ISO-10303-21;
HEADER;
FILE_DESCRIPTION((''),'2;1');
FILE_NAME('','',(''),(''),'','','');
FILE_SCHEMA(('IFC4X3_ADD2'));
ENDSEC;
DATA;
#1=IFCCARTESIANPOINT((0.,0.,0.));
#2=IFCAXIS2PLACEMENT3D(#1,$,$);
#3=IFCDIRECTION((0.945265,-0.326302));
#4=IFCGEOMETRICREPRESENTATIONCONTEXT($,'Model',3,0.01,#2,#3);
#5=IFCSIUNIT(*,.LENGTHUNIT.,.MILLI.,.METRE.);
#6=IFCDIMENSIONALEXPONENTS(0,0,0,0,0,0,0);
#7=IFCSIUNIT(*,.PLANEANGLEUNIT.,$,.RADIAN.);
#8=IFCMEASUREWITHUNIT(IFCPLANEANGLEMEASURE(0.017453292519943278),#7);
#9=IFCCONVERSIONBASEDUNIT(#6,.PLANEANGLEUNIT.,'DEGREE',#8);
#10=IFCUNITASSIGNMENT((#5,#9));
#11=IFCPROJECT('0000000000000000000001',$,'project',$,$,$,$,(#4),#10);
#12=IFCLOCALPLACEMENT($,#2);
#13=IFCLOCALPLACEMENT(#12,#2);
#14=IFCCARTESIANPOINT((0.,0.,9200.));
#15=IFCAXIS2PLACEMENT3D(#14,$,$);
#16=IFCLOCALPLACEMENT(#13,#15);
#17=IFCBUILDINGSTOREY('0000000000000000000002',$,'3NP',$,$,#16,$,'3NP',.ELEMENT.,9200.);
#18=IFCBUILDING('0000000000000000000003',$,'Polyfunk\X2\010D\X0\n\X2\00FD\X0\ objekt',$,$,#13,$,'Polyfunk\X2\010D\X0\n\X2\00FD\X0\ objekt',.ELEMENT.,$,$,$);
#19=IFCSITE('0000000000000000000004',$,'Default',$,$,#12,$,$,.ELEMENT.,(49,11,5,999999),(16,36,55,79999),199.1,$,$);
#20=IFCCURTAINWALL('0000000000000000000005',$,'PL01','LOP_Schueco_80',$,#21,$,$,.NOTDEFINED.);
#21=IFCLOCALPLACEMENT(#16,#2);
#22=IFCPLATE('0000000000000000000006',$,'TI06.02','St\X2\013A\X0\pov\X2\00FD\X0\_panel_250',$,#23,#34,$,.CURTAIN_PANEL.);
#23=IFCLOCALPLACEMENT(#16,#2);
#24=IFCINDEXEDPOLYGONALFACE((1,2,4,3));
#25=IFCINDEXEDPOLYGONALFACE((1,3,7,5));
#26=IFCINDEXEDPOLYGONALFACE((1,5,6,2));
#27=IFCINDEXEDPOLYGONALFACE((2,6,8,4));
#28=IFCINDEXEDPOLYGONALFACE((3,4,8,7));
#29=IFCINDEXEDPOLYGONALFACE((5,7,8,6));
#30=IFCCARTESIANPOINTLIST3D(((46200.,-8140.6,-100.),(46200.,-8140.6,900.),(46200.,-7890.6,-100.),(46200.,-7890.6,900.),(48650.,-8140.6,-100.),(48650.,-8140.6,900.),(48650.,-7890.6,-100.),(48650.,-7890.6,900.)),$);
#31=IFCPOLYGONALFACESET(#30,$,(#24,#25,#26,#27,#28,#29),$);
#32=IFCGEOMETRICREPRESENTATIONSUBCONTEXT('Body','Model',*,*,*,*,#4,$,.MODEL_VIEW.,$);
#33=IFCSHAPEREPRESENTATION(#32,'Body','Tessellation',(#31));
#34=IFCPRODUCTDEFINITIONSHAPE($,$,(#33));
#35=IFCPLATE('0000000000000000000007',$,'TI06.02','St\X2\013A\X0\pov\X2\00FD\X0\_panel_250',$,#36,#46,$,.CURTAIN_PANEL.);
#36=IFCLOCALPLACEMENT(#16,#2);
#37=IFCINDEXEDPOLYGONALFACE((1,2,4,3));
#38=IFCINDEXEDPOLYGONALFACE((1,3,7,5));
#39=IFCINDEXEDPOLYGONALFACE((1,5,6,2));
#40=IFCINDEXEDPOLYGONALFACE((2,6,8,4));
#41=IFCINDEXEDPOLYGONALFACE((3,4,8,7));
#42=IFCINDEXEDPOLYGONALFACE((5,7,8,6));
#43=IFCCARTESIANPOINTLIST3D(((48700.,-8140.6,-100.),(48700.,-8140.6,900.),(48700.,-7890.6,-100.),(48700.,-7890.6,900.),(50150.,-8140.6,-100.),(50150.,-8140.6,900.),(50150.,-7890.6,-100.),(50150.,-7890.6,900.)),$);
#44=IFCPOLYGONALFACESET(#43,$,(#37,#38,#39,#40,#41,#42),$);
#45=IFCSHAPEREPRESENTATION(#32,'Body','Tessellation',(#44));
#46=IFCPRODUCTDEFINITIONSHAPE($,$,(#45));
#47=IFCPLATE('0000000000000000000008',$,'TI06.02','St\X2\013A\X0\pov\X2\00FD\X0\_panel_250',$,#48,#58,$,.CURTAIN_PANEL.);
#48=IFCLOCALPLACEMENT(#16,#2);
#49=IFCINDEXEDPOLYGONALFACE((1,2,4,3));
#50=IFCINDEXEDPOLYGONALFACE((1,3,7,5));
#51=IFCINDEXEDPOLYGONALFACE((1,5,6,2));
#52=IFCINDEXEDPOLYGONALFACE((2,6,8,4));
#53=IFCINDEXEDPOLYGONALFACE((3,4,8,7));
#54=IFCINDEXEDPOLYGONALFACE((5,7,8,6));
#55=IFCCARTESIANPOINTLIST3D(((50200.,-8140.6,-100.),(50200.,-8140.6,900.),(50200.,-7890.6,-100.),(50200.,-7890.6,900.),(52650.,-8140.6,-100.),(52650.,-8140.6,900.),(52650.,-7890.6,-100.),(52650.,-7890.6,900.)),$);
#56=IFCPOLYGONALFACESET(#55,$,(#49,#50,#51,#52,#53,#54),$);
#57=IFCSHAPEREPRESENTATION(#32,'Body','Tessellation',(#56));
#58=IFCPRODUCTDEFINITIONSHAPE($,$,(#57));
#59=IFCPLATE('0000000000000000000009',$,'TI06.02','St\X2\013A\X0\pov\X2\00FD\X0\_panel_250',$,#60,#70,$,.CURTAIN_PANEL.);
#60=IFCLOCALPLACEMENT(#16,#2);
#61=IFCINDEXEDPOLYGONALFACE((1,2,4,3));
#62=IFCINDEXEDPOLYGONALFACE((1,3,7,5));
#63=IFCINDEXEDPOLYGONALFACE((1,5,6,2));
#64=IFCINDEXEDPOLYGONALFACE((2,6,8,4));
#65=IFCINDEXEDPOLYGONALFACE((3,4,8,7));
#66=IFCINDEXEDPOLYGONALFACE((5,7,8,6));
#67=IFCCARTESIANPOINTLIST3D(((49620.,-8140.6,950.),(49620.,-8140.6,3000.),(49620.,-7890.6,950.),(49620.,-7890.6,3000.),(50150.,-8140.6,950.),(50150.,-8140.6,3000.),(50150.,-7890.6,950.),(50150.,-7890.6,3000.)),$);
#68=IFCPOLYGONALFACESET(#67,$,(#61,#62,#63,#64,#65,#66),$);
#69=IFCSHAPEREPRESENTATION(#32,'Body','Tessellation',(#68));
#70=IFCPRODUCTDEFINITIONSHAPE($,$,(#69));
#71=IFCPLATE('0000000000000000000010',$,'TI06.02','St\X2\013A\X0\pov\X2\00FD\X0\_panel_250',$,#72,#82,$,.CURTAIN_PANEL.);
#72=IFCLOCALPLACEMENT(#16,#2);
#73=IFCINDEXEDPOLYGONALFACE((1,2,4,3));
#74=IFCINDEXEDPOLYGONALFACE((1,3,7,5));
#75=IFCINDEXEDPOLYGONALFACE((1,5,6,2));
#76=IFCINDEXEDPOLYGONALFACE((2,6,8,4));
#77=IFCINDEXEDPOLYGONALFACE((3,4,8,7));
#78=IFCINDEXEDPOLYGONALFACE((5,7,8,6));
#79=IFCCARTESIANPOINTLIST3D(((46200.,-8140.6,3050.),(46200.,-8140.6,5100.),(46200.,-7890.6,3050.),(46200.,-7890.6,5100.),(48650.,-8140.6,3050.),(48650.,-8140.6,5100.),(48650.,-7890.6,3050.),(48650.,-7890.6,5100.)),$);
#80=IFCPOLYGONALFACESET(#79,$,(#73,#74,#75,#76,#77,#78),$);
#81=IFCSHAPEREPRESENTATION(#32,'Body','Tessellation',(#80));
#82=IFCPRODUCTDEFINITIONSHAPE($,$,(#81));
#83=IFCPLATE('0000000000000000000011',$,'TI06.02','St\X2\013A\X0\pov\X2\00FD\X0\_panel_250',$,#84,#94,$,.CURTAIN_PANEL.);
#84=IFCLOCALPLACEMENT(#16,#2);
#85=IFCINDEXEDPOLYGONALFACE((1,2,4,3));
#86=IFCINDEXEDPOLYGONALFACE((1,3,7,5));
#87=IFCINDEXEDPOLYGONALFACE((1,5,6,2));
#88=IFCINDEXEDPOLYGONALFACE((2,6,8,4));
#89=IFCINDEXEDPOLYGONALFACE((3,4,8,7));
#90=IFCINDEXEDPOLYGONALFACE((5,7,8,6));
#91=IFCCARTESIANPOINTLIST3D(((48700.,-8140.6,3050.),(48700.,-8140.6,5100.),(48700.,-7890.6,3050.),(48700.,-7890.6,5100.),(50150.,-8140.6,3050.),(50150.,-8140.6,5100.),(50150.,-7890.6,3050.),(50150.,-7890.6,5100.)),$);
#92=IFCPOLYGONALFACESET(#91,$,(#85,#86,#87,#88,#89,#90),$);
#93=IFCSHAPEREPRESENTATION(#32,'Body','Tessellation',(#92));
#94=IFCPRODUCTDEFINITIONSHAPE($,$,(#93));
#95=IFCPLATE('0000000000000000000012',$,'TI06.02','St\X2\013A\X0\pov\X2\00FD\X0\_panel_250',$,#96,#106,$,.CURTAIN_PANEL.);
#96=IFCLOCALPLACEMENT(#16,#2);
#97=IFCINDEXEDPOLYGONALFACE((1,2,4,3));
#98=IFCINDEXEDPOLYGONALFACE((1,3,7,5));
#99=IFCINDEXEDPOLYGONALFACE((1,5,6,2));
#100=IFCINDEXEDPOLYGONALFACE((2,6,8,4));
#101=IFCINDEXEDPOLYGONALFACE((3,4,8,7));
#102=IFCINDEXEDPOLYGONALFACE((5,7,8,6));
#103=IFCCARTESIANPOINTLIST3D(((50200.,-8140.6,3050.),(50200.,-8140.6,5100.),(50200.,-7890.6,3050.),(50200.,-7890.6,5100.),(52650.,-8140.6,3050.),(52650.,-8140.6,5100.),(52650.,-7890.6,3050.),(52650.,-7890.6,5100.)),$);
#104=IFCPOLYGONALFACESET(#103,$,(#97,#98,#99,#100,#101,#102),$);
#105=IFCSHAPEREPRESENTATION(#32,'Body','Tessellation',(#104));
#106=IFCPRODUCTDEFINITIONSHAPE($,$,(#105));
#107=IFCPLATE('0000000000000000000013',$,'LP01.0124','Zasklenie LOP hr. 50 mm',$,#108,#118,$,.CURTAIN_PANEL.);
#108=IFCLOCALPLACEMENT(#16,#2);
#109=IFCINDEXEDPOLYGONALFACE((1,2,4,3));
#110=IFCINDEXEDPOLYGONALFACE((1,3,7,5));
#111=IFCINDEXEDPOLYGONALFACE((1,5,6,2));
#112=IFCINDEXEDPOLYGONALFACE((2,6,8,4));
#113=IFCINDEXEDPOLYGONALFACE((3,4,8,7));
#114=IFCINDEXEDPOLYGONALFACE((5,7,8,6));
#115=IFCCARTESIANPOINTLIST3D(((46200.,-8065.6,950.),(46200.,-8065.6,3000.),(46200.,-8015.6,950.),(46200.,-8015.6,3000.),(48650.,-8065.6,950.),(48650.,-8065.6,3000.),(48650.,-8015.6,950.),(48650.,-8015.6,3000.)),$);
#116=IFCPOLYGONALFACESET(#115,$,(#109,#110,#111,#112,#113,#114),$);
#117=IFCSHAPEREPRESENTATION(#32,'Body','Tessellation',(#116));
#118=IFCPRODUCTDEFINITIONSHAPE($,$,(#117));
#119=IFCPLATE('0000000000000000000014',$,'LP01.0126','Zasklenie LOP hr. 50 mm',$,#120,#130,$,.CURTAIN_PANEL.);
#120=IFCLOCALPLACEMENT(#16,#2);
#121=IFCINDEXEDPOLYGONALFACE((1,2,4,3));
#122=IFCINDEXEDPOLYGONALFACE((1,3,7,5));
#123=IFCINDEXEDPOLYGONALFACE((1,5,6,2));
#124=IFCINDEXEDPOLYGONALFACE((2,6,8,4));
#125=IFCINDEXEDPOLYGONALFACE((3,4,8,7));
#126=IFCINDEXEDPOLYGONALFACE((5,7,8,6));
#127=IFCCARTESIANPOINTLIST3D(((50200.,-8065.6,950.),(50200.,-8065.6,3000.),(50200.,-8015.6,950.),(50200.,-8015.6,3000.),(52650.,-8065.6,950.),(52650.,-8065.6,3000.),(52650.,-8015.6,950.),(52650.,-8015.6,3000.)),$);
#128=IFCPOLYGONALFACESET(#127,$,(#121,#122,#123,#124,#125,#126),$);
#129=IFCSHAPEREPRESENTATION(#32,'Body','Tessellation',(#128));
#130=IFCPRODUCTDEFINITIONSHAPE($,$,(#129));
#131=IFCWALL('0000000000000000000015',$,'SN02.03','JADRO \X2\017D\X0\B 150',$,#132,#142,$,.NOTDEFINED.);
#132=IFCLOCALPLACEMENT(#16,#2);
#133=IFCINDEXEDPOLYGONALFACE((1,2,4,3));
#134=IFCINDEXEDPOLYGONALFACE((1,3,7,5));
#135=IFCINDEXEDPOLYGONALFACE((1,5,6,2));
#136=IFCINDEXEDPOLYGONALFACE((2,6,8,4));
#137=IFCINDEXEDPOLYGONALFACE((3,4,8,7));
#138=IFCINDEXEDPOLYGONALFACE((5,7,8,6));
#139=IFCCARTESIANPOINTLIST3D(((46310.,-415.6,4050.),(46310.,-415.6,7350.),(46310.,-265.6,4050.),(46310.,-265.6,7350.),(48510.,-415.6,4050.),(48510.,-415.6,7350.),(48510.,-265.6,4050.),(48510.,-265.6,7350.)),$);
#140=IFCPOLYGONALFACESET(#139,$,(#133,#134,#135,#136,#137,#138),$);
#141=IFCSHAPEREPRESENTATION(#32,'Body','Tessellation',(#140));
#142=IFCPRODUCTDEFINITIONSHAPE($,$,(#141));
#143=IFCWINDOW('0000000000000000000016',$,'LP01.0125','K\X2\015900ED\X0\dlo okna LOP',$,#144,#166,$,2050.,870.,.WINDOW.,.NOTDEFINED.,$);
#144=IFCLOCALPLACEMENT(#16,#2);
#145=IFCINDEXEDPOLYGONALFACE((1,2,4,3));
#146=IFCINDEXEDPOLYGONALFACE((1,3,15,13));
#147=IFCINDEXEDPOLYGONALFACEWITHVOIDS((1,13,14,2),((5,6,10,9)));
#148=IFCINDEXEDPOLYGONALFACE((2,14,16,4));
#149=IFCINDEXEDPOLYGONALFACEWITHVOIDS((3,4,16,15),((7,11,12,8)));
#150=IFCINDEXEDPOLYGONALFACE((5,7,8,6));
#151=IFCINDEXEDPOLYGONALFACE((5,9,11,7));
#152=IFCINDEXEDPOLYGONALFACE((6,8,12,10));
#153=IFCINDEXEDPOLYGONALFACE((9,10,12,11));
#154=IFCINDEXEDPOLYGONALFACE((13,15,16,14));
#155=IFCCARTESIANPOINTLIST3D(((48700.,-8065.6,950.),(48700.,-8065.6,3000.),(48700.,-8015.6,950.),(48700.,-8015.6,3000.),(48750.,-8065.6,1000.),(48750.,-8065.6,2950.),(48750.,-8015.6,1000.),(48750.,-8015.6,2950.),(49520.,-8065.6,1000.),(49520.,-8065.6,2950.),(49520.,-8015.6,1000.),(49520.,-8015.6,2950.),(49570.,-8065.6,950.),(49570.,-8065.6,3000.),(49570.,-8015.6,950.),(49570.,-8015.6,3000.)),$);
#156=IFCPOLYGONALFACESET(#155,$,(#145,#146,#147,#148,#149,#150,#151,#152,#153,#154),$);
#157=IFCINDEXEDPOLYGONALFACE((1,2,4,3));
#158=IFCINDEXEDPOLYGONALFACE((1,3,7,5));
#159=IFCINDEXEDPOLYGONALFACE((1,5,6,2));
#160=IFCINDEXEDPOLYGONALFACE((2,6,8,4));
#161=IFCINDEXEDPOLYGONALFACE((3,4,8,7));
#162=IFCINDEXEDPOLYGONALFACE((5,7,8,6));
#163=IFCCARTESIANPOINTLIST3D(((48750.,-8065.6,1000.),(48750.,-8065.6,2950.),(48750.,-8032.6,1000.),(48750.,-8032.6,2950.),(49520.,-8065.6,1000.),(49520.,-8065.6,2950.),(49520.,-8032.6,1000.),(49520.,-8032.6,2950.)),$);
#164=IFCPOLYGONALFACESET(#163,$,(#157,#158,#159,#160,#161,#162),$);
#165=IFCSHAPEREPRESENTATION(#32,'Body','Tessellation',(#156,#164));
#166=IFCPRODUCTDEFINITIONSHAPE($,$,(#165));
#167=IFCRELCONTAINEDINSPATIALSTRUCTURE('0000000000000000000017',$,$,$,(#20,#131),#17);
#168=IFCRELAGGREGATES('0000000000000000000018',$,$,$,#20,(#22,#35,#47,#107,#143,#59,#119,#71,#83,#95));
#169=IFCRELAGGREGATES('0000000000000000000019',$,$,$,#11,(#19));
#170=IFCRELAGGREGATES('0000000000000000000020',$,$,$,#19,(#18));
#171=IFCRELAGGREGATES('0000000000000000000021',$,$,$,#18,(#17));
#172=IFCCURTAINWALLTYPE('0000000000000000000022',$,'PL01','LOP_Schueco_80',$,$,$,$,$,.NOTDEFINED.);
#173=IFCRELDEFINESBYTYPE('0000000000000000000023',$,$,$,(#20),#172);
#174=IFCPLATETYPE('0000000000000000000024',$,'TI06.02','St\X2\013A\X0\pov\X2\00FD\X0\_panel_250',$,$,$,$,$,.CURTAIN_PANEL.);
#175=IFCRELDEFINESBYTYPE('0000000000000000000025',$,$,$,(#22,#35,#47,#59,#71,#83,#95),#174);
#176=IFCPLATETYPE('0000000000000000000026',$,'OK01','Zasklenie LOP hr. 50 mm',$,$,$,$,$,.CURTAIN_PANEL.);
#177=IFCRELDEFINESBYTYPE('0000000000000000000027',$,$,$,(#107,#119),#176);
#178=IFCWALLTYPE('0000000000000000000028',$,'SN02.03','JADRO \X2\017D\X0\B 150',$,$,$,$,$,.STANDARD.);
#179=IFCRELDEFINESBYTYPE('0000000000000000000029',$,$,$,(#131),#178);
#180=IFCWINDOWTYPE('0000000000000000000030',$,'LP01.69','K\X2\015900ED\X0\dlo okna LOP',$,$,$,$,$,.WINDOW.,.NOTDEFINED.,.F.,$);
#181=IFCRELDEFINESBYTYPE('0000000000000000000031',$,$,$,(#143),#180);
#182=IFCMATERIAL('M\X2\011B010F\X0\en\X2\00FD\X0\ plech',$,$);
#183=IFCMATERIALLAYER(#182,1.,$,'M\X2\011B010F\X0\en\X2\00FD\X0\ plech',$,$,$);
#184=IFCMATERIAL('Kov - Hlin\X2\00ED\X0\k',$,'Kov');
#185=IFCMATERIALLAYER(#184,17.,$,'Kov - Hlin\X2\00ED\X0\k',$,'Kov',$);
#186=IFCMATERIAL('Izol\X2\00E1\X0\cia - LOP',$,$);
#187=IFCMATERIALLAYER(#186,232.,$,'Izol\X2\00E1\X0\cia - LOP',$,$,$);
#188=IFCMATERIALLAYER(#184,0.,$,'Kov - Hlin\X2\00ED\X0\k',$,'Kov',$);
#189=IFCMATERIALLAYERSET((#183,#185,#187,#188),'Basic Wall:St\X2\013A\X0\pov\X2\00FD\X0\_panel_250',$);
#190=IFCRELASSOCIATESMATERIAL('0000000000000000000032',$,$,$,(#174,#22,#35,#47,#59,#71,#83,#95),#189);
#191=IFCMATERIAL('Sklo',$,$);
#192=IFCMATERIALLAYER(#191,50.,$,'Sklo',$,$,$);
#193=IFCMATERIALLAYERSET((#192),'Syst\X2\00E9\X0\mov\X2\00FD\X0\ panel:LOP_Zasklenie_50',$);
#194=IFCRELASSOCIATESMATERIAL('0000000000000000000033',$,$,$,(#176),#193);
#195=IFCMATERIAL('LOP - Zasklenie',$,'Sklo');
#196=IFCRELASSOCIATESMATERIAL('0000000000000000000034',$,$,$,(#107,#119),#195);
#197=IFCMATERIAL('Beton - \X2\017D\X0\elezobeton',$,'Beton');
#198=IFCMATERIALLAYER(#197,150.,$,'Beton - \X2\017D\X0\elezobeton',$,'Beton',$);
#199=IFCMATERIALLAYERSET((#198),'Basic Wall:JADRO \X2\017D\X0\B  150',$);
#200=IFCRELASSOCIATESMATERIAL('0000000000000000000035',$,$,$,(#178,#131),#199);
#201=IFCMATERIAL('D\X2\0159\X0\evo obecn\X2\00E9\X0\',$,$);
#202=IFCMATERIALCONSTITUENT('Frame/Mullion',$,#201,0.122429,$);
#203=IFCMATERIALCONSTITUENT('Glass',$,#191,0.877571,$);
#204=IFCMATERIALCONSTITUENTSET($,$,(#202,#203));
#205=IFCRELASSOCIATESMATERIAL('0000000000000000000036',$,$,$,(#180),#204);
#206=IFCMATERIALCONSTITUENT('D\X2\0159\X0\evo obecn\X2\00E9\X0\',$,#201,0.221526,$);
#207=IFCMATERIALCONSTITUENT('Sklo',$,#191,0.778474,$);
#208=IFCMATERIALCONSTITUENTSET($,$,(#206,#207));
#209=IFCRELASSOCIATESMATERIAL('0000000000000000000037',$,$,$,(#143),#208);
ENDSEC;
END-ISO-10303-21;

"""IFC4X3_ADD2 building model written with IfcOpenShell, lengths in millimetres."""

from ifc_helpers import new_model, entity, si_unit, converted_unit, direction, frame, frame_2d, origin, origin_2d_with_axis, place, context, subcontext, project, spatial, polyline, rectangle, outline, extrude, clip, bounded_halfspace, source, transform, mapped, material, layer, layer_set, layer_usage, constituent, constituent_set, type_object, type_shapes, element, aggregate, save


model = new_model("IFC4X3_ADD2")

# Units and contexts
model_context = context("Model", 3, precision=0.01, world=origin(), true_north=direction((0.945265, -0.326302)))
body_context = subcontext(model_context, "Body", "Model", "MODEL_VIEW")
ifc_project = project(units=[si_unit("LENGTHUNIT", "METRE", prefix="MILLI"), converted_unit("PLANEANGLEUNIT", "DEGREE", entity("IfcPlaneAngleMeasure", 0.017453292519943278), si_unit("PLANEANGLEUNIT", "RADIAN"), dimensions=[0, 0, 0, 0, 0, 0, 0])], contexts=[model_context])

# Site, building, storey
site_placement = place(None, origin())
site = spatial("IfcSite", under=ifc_project, at=site_placement, Name="Default", CompositionType="ELEMENT", RefLatitude=(49, 11, 5, 999999), RefLongitude=(16, 36, 55, 79999), RefElevation=199.1)
building_placement = place(site_placement, origin())
building = spatial("IfcBuilding", under=site, at=building_placement, Name="Polyfunkčný objekt", LongName="Polyfunkčný objekt", CompositionType="ELEMENT")
storey_placement = place(building_placement, frame((0.0, 0.0, 9200.0)))
storey = spatial("IfcBuildingStorey", under=building, at=storey_placement, Name="3NP", LongName="3NP", CompositionType="ELEMENT", Elevation=9200.0)

# Curtain wall, plates
curtain_wall_type = type_object("IfcCurtainWallType", Name="PL01", Description="LOP_Schueco_80", PredefinedType="NOTDEFINED")
curtain_wall_placement = place(storey_placement, frame((0.0, 0.0, -9200.0)))
curtain_wall = element("IfcCurtainWall", 1, at=curtain_wall_placement, inside=storey, type_object=curtain_wall_type, Name="PL01", Description="LOP_Schueco_80", PredefinedType="NOTDEFINED")
ifc_material_1 = material(Name="Měďený plech")
ifc_layer_1 = layer(ifc_material_1, 1.0, Name="Měďený plech")
ifc_material_2 = material(Name="Kov - Hliník", Category="Kov")
ifc_layer_2 = layer(ifc_material_2, 17.0, Name="Kov - Hliník", Category="Kov")
ifc_material_3 = material(Name="Izolácia - LOP")
ifc_layer_3 = layer(ifc_material_3, 232.0, Name="Izolácia - LOP")
ifc_layer_4 = layer(ifc_material_2, 0.0, Name="Kov - Hliník", Category="Kov")
ifc_layer_set_1 = layer_set([ifc_layer_1, ifc_layer_2, ifc_layer_3, ifc_layer_4], Name="Basic Wall:Stĺpový_panel_250")
ifc_layer_usage_1 = layer_usage(ifc_layer_set_1, "AXIS2", "POSITIVE", -125.0)
plate_type_1 = type_object("IfcPlateType", Name="TI06.02", Description="Stĺpový_panel_250", PredefinedType="CURTAIN_PANEL", material=ifc_layer_set_1)
plate_1_placement = place(storey_placement, frame((46200.0, -8015.6, -100.0)))
plate_1 = element("IfcPlate", 2, at=plate_1_placement, type_object=plate_type_1, material=ifc_layer_usage_1, Name="TI06.02", Description="Stĺpový_panel_250", PredefinedType="CURTAIN_PANEL", context=body_context, shape_type="SweptSolid", body=[
    extrude(rectangle(XDim=250.0, YDim=2450.0, at=frame_2d((0.0, 0.0), x_axis=(1.0, 0.0))), frame((1225.0, 0.0, 0.0), z_axis=(0.0, 0.0, 1.0), x_axis=(0.0, 1.0, 0.0)), (0.0, 0.0, 1.0), 1000.0),
])
ifc_layer_usage_2 = layer_usage(ifc_layer_set_1, "AXIS2", "POSITIVE", -125.0)
plate_2_placement = place(storey_placement, frame((48700.0, -8015.6, -100.0)))
plate_2 = element("IfcPlate", 3, at=plate_2_placement, type_object=plate_type_1, material=ifc_layer_usage_2, Name="TI06.02", Description="Stĺpový_panel_250", PredefinedType="CURTAIN_PANEL", context=body_context, shape_type="SweptSolid", body=[
    extrude(rectangle(XDim=250.0, YDim=1450.0, at=frame_2d((0.0, 0.0), x_axis=(1.0, 0.0))), frame((725.0, 0.0, 0.0), z_axis=(0.0, 0.0, 1.0), x_axis=(0.0, 1.0, 0.0)), (0.0, 0.0, 1.0), 1000.0),
])
ifc_layer_usage_3 = layer_usage(ifc_layer_set_1, "AXIS2", "POSITIVE", -125.0)
plate_3_placement = place(storey_placement, frame((50200.0, -8015.6, -100.0)))
plate_3 = element("IfcPlate", 4, at=plate_3_placement, type_object=plate_type_1, material=ifc_layer_usage_3, Name="TI06.02", Description="Stĺpový_panel_250", PredefinedType="CURTAIN_PANEL", context=body_context, shape_type="SweptSolid", body=[
    extrude(rectangle(XDim=250.0, YDim=2450.0, at=origin_2d_with_axis()), frame((1225.0, 0.0, 0.0), z_axis=(0.0, 0.0, 1.0), x_axis=(0.0, 1.0, 0.0)), (0.0, 0.0, 1.0), 1000.0),
])
ifc_layer_usage_4 = layer_usage(ifc_layer_set_1, "AXIS2", "POSITIVE", -125.0)
plate_4_placement = place(storey_placement, frame((49620.0, -8015.6, 950.0)))
plate_4 = element("IfcPlate", 5, at=plate_4_placement, type_object=plate_type_1, material=ifc_layer_usage_4, Name="TI06.02", Description="Stĺpový_panel_250", PredefinedType="CURTAIN_PANEL", context=body_context, shape_type="SweptSolid", body=[
    extrude(rectangle(XDim=250.0, YDim=530.0, at=origin_2d_with_axis()), frame((265.0, 0.0, 0.0), z_axis=(0.0, 0.0, 1.0), x_axis=(0.0, 1.0, 0.0)), (0.0, 0.0, 1.0), 2050.0),
])
ifc_layer_usage_5 = layer_usage(ifc_layer_set_1, "AXIS2", "POSITIVE", -125.0)
plate_5_placement = place(storey_placement, frame((46200.0, -8015.6, 3050.0)))
plate_5 = element("IfcPlate", 6, at=plate_5_placement, type_object=plate_type_1, material=ifc_layer_usage_5, Name="TI06.02", Description="Stĺpový_panel_250", PredefinedType="CURTAIN_PANEL", context=body_context, shape_type="SweptSolid", body=[
    extrude(rectangle(XDim=250.0, YDim=2450.0, at=frame_2d((0.0, 0.0), x_axis=(1.0, 0.0))), frame((1225.0, 0.0, 0.0), z_axis=(0.0, 0.0, 1.0), x_axis=(0.0, 1.0, 0.0)), (0.0, 0.0, 1.0), 2050.0),
])
ifc_layer_usage_6 = layer_usage(ifc_layer_set_1, "AXIS2", "POSITIVE", -125.0)
plate_6_placement = place(storey_placement, frame((48700.0, -8015.6, 3050.0)))
plate_6 = element("IfcPlate", 7, at=plate_6_placement, type_object=plate_type_1, material=ifc_layer_usage_6, Name="TI06.02", Description="Stĺpový_panel_250", PredefinedType="CURTAIN_PANEL", context=body_context, shape_type="SweptSolid", body=[
    extrude(rectangle(XDim=250.0, YDim=1450.0, at=frame_2d((0.0, 0.0), x_axis=(1.0, 0.0))), frame((725.0, 0.0, 0.0), z_axis=(0.0, 0.0, 1.0), x_axis=(0.0, 1.0, 0.0)), (0.0, 0.0, 1.0), 2050.0),
])
ifc_layer_usage_7 = layer_usage(ifc_layer_set_1, "AXIS2", "POSITIVE", -125.0)
plate_7_placement = place(storey_placement, frame((50200.0, -8015.6, 3050.0)))
plate_7 = element("IfcPlate", 8, at=plate_7_placement, type_object=plate_type_1, material=ifc_layer_usage_7, Name="TI06.02", Description="Stĺpový_panel_250", PredefinedType="CURTAIN_PANEL", context=body_context, shape_type="SweptSolid", body=[
    extrude(rectangle(XDim=250.0, YDim=2450.0, at=origin_2d_with_axis()), frame((1225.0, 0.0, 0.0), z_axis=(0.0, 0.0, 1.0), x_axis=(0.0, 1.0, 0.0)), (0.0, 0.0, 1.0), 2050.0),
])
ifc_material_4 = material(Name="LOP - Zasklenie", Category="Sklo")
ifc_material_5 = material(Name="Sklo")
ifc_layer_5 = layer(ifc_material_5, 50.0, Name="Sklo")
ifc_layer_set_2 = layer_set([ifc_layer_5], Name="Systémový panel:LOP_Zasklenie_50")
plate_type_2 = type_object("IfcPlateType", Name="OK01", Description="Zasklenie LOP hr. 50 mm", PredefinedType="CURTAIN_PANEL", material=ifc_layer_set_2)
shared_shape_1 = source(origin(), body_context, "Body", "SweptSolid", [
    extrude(rectangle(XDim=50.0, YDim=2450.0, at=origin_2d_with_axis()), frame((0.0, -25.0, 0.0), z_axis=(0.0, 0.0, 1.0), x_axis=(0.0, 1.0, 0.0)), (0.0, 0.0, 1.0), 2050.0),
])
type_shapes(plate_type_2, [shared_shape_1])
plate_8_placement = place(curtain_wall_placement, frame((47425.0, -8015.6, 10150.0)))
plate_8 = element("IfcPlate", 9, at=plate_8_placement, type_object=plate_type_2, material=ifc_material_4, Name="LP01.0124", Description="Zasklenie LOP hr. 50 mm", PredefinedType="CURTAIN_PANEL", context=body_context, shape_type="MappedRepresentation", body=[
    mapped(shared_shape_1, transform((0.0, 0.0, 0.0), scale=1.0)),
])
plate_9_placement = place(curtain_wall_placement, frame((51425.0, -8015.6, 10150.0)))
plate_9 = element("IfcPlate", 10, at=plate_9_placement, type_object=plate_type_2, material=ifc_material_4, Name="LP01.0126", Description="Zasklenie LOP hr. 50 mm", PredefinedType="CURTAIN_PANEL", context=body_context, shape_type="MappedRepresentation", body=[
    mapped(shared_shape_1, transform((0.0, 0.0, 0.0), scale=1.0)),
])

# Wall
ifc_material_6 = material(Name="Beton - Železobeton", Category="Beton")
ifc_layer_6 = layer(ifc_material_6, 150.0, Name="Beton - Železobeton", Category="Beton")
ifc_layer_set_3 = layer_set([ifc_layer_6], Name="Basic Wall:JADRO ŽB  150")
wall_type_1 = type_object("IfcWallType", Name="SN02.03", Description="JADRO ŽB 150", PredefinedType="STANDARD", material=ifc_layer_set_3)
wall_1_placement = place(storey_placement, frame((46310.0, -340.6, 4050.0)))
element("IfcWall", 11, at=wall_1_placement, inside=storey, type_object=wall_type_1, material=ifc_layer_set_3, Name="SN02.03", Description="JADRO ŽB 150", PredefinedType="NOTDEFINED", context=body_context, shape_type="Clipping", body=[
    clip(extrude(rectangle(XDim=2200.0, YDim=150.0, at=frame_2d((1100.0, 0.0), x_axis=(-1.0, 0.0))), origin(), (0.0, 0.0, 1.0), 3300.0), bounded_halfspace(frame((2200.0, -75.0, 0.0), z_axis=(0.0, 0.0, 1.0), x_axis=(-1.0, 0.0, 0.0)), True, frame((2200.0, -75.0, 0.0)), polyline([(0.0, 0.0), (0.0, 150.0), (-2200.0, 150.0), (-2200.0, 0.0), (-150.0, 0.0), (0.0, 0.0)]))),
])

# Window
ifc_material_7 = material(Name="Dřevo obecné")
ifc_constituent_1 = constituent(ifc_material_7, Name="Dřevo obecné", fraction=0.221526)
ifc_constituent_2 = constituent(ifc_material_5, Name="Sklo", fraction=0.778474)
ifc_constituent_set_1 = constituent_set(constituents=[ifc_constituent_1, ifc_constituent_2])
ifc_constituent_3 = constituent(ifc_material_7, Name="Frame/Mullion", fraction=0.122429)
ifc_constituent_4 = constituent(ifc_material_5, Name="Glass", fraction=0.877571)
ifc_constituent_set_2 = constituent_set(constituents=[ifc_constituent_3, ifc_constituent_4])
window_type = type_object("IfcWindowType", Name="LP01.69", Description="Křídlo okna LOP", ParameterTakesPrecedence=False, PartitioningType="NOTDEFINED", PredefinedType="WINDOW", material=ifc_constituent_set_2)
shared_shape_2 = source(origin(), body_context, "Body", "SweptSolid", [
    extrude(outline(polyline([(-1025.0, -435.0), (1025.0, -435.0), (1025.0, 435.0), (-1025.0, 435.0), (-1025.0, -435.0)]), holes=[polyline([(-975.0, -385.0), (-975.0, 385.0), (975.0, 385.0), (975.0, -385.0), (-975.0, -385.0)])]), frame((0.0, 50.0, 1025.0), z_axis=(0.0, -1.0, 0.0), x_axis=(0.0, 0.0, -1.0)), (0.0, 0.0, 1.0), 50.0),
    extrude(rectangle(XDim=770.0, YDim=33.0, at=frame_2d((0.0, 0.0), x_axis=(1.0, 0.0))), frame((0.0, 33.5, 50.0), z_axis=(0.0, 0.0, 1.0), x_axis=(-1.0, 0.0, 0.0)), (0.0, 0.0, 1.0), 1950.0),
])
type_shapes(window_type, [shared_shape_2])
window_placement = place(curtain_wall_placement, frame((49135.0, -8015.6, 10150.0), z_axis=(0.0, 0.0, 1.0), x_axis=(-1.0, 0.0, 0.0)))
window = element("IfcWindow", 12, at=window_placement, type_object=window_type, material=ifc_constituent_set_1, Name="LP01.0125", Description="Křídlo okna LOP", OverallHeight=2050.0, OverallWidth=870.0, PartitioningType="NOTDEFINED", PredefinedType="WINDOW", context=body_context, shape_type="MappedRepresentation", body=[
    mapped(shared_shape_2, transform((0.0, 0.0, 0.0), scale=1.0)),
])
aggregate(curtain_wall, [plate_1, plate_2, plate_3, plate_8, window, plate_4, plate_9, plate_5, plate_6, plate_7])

save(model, "model.ifc")
